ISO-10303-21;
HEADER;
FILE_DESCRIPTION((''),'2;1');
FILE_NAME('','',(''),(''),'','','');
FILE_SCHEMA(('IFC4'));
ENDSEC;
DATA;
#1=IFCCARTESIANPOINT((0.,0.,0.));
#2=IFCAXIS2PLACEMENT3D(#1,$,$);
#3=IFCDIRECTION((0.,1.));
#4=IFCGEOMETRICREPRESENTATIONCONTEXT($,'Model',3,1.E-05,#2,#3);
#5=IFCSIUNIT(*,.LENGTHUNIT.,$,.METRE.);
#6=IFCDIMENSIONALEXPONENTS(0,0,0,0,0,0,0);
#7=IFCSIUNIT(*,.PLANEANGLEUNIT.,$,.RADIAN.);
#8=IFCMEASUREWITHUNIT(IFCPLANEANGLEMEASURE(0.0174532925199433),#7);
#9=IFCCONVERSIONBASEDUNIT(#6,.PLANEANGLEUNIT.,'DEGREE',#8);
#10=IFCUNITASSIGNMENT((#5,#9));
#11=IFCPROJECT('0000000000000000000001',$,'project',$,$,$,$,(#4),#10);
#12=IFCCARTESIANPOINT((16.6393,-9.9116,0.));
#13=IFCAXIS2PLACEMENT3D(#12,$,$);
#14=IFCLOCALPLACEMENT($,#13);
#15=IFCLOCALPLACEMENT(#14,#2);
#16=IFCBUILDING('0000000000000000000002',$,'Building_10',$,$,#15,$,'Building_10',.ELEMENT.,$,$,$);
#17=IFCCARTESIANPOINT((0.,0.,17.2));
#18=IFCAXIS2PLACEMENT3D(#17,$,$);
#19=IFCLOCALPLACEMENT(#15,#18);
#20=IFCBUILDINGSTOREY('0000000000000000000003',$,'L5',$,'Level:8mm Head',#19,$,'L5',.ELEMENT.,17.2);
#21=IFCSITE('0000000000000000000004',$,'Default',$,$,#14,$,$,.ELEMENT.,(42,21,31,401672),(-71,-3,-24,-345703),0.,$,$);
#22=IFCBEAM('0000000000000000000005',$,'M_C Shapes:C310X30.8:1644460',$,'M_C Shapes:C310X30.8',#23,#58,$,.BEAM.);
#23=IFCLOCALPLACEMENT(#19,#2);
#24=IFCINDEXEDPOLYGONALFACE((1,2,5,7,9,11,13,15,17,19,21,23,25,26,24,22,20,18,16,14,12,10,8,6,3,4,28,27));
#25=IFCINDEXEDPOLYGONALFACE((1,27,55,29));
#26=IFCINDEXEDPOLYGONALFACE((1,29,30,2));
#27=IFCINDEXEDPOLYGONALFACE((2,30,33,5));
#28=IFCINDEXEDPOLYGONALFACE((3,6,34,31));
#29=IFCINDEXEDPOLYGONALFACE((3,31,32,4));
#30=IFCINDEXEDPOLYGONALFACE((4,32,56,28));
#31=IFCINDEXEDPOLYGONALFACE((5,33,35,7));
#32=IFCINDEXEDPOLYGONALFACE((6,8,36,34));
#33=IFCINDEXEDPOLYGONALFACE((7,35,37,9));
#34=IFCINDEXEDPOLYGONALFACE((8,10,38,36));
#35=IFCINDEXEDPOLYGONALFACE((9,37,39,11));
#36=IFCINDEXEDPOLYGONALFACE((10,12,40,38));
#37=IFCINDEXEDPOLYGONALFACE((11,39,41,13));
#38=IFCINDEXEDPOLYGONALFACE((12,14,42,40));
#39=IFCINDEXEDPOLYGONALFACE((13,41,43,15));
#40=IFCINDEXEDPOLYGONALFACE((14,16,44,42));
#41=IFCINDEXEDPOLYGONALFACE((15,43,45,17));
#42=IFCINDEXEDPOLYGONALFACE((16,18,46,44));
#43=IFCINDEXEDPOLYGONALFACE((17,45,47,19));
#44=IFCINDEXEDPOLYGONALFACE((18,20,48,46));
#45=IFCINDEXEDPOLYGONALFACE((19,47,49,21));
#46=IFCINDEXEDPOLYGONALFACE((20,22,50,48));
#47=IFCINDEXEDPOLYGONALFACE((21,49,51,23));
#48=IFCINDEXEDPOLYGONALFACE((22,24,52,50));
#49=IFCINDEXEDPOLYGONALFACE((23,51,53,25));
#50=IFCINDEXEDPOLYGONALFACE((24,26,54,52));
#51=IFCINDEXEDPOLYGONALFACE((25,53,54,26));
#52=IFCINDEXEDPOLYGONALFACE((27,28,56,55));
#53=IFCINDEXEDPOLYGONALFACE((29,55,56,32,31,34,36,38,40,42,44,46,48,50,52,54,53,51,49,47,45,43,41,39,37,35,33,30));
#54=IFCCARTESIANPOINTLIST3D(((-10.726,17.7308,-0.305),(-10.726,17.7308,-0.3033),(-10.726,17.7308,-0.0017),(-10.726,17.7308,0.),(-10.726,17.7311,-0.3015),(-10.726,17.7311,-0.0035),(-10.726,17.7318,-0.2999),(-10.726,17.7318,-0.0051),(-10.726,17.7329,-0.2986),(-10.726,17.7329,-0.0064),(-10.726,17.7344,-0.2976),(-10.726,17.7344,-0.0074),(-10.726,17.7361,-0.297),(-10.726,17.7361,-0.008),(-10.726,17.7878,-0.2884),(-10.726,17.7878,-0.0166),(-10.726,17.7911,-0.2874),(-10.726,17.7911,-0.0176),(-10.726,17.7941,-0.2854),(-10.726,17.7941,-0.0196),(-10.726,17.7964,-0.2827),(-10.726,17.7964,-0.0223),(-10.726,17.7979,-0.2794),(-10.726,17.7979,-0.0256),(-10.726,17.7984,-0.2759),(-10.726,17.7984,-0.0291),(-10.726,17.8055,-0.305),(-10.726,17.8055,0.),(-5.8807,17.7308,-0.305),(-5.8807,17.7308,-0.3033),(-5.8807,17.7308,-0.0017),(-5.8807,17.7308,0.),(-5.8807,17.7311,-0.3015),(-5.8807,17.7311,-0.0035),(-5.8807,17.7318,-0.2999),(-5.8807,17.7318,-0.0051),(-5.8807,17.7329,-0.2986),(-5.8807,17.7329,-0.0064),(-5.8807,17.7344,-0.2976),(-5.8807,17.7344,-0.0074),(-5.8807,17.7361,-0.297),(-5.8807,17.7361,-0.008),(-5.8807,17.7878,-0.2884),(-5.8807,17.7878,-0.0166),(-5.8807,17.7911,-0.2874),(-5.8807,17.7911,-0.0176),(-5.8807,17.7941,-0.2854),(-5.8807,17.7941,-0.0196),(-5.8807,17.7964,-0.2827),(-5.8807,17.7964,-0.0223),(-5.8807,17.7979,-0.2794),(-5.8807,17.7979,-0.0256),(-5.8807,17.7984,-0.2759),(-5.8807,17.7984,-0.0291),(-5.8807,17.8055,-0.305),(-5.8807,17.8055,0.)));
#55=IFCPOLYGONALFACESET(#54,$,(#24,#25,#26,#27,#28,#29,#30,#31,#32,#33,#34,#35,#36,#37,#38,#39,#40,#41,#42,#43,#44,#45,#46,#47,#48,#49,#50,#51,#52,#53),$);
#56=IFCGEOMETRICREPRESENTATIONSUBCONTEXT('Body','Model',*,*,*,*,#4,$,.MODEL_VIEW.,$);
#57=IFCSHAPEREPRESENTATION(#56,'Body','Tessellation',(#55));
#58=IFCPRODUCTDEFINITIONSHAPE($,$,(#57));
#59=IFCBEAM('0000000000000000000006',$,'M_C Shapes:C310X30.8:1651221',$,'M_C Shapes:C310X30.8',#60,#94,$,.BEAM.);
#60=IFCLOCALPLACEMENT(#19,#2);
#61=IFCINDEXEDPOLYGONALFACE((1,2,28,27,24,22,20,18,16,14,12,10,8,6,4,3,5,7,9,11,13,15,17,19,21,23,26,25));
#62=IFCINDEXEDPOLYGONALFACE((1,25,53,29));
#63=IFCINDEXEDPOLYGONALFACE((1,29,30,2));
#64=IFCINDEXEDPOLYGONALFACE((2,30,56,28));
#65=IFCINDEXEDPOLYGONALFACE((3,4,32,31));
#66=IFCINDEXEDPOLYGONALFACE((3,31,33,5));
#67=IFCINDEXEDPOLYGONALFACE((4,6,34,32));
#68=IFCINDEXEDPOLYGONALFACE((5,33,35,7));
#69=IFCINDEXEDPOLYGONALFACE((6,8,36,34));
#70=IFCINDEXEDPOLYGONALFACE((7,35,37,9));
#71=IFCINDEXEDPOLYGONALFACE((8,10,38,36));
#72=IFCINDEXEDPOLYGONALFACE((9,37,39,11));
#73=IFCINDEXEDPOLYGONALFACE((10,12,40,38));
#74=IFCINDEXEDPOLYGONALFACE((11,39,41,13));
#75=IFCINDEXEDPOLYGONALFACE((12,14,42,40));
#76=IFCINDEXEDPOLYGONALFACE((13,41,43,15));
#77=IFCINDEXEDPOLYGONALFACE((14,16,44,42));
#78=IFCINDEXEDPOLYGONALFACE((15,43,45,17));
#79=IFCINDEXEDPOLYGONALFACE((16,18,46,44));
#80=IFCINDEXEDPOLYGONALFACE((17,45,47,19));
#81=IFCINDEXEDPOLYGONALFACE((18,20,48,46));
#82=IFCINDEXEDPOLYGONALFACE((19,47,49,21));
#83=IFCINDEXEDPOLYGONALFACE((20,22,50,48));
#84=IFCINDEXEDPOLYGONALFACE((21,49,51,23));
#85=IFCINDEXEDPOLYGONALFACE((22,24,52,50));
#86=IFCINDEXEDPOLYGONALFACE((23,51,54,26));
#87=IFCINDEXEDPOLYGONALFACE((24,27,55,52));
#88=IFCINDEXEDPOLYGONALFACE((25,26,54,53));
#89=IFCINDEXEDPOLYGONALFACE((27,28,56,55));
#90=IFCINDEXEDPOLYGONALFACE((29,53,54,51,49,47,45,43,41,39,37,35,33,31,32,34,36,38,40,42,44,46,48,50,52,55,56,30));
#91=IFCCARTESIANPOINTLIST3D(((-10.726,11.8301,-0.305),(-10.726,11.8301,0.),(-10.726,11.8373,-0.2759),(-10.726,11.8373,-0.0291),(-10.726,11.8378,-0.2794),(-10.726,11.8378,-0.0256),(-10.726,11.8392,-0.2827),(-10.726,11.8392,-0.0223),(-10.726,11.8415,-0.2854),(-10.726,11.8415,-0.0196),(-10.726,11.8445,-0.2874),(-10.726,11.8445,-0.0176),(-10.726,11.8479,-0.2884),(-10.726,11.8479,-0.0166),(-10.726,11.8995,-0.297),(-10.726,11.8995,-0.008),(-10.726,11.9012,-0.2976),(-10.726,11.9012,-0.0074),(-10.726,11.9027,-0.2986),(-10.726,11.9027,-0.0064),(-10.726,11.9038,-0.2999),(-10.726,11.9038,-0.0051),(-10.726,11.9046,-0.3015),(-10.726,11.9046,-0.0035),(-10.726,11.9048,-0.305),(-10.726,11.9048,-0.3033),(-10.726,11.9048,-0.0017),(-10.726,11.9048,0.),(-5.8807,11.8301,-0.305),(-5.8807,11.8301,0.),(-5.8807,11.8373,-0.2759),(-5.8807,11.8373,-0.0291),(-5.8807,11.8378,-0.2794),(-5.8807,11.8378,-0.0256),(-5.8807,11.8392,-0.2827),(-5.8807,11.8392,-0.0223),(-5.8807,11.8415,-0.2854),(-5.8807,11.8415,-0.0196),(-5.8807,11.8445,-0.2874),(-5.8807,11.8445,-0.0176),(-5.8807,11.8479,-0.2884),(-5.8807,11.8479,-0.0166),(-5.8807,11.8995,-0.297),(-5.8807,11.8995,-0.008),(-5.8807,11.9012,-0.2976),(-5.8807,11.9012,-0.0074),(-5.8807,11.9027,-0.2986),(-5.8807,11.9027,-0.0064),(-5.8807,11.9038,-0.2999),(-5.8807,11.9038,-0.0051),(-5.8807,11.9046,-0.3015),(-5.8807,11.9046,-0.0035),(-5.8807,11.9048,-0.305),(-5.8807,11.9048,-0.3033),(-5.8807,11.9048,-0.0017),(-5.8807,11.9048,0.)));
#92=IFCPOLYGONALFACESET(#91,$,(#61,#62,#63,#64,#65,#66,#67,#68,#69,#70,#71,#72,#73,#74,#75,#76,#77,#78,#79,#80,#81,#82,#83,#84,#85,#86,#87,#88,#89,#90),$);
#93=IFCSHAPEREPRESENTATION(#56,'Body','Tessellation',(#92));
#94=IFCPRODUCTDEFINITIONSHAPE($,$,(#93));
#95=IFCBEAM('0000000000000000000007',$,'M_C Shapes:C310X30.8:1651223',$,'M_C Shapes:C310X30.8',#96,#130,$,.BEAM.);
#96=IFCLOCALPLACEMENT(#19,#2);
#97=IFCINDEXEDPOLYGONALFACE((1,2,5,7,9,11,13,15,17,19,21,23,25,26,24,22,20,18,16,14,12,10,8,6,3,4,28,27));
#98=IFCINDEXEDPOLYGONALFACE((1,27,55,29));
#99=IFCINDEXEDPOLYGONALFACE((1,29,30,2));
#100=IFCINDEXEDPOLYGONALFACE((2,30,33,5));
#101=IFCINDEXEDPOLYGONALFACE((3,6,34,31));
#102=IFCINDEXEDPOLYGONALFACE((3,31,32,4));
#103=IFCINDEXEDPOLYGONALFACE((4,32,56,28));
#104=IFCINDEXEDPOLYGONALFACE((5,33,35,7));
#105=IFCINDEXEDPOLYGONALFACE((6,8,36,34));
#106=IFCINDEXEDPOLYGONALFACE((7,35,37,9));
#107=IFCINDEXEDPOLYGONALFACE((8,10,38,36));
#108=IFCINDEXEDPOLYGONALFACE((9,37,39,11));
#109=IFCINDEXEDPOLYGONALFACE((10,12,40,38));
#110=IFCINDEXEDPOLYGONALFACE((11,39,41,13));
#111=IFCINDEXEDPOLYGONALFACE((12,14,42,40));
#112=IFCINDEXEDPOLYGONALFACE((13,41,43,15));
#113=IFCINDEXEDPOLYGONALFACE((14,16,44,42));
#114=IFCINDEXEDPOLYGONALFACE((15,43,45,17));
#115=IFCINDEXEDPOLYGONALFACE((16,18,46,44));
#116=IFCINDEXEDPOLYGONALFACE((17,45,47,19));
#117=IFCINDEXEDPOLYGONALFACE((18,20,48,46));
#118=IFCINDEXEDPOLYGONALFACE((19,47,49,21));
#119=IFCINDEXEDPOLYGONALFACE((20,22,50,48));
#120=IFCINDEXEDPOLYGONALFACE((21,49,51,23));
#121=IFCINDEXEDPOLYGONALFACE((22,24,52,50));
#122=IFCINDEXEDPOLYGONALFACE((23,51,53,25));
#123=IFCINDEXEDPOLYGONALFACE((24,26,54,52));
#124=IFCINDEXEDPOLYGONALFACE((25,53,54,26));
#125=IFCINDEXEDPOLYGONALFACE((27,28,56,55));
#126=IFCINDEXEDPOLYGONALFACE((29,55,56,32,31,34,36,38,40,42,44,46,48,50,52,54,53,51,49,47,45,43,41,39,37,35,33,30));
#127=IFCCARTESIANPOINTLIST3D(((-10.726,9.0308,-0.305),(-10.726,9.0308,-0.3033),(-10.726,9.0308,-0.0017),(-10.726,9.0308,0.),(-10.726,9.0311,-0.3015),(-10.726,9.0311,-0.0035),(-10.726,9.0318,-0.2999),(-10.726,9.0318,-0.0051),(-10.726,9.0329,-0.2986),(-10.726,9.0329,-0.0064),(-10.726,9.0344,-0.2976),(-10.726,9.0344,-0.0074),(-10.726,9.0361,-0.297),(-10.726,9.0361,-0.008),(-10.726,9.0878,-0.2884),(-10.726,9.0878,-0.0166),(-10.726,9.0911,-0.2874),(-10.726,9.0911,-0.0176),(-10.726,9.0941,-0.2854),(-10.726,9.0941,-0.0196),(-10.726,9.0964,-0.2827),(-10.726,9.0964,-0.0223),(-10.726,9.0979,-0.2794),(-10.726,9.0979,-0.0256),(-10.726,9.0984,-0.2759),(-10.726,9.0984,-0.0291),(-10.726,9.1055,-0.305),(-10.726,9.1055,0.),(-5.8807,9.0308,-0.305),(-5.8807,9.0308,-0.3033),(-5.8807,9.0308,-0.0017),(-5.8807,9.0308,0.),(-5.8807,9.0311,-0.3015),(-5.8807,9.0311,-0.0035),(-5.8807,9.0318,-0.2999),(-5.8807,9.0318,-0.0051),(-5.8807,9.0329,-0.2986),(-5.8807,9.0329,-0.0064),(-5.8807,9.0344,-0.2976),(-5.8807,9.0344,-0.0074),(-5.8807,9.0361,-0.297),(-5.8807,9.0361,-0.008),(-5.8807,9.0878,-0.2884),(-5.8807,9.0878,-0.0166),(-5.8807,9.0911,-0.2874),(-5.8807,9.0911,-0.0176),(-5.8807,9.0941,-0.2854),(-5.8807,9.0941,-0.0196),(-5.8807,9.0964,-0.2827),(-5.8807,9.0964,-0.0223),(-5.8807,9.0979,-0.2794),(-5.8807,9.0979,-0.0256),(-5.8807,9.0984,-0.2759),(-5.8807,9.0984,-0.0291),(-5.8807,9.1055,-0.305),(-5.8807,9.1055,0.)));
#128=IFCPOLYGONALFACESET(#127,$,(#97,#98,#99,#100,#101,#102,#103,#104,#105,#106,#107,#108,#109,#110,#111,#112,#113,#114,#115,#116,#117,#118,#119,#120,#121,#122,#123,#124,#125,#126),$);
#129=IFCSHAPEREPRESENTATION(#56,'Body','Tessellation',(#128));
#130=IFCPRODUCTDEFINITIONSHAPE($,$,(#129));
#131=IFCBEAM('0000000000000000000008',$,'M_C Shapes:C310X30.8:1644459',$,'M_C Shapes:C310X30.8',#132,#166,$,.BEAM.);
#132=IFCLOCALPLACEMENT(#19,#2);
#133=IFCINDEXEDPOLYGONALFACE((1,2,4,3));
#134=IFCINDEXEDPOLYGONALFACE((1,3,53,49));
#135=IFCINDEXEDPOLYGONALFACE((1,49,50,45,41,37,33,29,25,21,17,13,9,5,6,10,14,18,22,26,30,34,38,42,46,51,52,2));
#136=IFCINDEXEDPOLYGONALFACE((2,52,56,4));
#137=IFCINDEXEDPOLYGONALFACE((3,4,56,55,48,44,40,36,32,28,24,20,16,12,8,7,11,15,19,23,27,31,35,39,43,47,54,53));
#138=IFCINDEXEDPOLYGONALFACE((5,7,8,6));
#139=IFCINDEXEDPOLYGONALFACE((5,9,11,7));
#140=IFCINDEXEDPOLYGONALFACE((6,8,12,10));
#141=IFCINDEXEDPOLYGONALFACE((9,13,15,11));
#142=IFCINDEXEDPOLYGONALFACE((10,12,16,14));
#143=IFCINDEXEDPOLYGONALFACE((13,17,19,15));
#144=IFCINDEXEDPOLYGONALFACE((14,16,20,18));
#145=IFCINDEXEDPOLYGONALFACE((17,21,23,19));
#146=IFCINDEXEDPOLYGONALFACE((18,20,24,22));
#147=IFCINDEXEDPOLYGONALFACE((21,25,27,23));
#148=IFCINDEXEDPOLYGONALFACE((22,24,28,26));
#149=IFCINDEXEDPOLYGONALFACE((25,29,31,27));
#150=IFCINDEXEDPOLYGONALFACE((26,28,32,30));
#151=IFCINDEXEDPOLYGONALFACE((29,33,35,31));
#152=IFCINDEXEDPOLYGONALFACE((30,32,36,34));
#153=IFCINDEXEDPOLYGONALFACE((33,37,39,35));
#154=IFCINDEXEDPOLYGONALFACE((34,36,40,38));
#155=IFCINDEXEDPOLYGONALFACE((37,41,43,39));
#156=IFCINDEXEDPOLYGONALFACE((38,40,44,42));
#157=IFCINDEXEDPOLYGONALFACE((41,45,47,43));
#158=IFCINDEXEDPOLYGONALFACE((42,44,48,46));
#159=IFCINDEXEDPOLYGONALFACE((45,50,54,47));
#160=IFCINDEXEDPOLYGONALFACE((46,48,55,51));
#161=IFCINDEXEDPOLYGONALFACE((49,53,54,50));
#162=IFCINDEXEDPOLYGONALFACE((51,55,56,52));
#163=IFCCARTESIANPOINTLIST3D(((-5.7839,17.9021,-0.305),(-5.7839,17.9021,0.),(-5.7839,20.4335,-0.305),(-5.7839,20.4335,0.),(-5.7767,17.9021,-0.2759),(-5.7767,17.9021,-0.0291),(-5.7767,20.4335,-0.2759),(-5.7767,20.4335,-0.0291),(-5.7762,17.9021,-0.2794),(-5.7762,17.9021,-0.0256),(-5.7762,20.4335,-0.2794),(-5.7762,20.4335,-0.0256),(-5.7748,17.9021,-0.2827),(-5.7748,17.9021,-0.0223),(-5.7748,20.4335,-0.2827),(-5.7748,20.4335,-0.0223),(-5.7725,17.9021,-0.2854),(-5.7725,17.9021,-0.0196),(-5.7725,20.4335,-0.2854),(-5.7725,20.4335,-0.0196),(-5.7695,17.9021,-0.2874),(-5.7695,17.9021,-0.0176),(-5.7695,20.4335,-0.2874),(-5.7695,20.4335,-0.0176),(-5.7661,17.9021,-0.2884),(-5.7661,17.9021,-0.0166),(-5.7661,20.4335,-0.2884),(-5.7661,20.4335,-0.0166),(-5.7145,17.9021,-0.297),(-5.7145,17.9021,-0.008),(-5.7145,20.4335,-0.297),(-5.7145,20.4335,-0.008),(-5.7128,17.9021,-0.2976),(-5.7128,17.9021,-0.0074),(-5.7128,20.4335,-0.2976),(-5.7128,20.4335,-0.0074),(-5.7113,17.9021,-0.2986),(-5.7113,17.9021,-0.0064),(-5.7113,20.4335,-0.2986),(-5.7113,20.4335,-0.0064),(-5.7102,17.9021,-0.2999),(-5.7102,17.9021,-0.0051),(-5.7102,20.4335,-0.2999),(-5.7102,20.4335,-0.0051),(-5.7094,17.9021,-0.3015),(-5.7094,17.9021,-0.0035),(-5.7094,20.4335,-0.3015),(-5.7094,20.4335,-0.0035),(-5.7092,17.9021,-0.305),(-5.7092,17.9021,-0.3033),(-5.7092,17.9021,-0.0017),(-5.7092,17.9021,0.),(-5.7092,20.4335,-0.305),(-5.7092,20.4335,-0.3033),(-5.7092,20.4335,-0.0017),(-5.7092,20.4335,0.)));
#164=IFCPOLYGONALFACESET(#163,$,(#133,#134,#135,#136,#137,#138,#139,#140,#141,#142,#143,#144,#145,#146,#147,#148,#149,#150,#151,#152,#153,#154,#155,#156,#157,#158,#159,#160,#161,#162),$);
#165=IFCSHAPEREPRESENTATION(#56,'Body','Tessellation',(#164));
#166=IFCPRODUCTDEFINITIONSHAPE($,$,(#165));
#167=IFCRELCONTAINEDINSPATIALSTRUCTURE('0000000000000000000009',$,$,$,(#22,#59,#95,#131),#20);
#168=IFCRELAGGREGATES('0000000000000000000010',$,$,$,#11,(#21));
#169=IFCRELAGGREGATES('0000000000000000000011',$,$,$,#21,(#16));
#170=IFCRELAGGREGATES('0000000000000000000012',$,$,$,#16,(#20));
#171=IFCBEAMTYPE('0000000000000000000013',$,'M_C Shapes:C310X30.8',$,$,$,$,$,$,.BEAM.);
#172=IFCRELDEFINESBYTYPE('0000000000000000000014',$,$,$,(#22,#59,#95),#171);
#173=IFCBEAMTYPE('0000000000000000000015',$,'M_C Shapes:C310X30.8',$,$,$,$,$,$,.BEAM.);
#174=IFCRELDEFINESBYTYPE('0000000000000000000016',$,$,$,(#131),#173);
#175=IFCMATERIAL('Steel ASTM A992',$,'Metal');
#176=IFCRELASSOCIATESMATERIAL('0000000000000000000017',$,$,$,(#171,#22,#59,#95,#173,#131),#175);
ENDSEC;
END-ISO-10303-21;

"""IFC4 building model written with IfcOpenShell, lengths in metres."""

from ifc_helpers import new_model, entity, si_unit, converted_unit, direction, frame, origin, place, context, subcontext, project, spatial, line, arc, indexed_curve, outline, extrude, source, transform, mapped, material, type_object, type_shapes, element, save


model = new_model("IFC4")

# Units and contexts
model_context = context("Model", 3, precision=1e-05, world=origin(), true_north=direction((0.0, 1.0)))
body_context = subcontext(model_context, "Body", "Model", "MODEL_VIEW")
ifc_project = project(units=[si_unit("LENGTHUNIT", "METRE"), converted_unit("PLANEANGLEUNIT", "DEGREE", entity("IfcPlaneAngleMeasure", 0.0174532925199433), si_unit("PLANEANGLEUNIT", "RADIAN"), dimensions=[0, 0, 0, 0, 0, 0, 0])], contexts=[model_context])

# Site, building, storey
site_placement = place(None, frame((16.6393, -9.9116, 0.0)))
site = spatial("IfcSite", under=ifc_project, at=site_placement, Name="Default", CompositionType="ELEMENT", RefLatitude=(42, 21, 31, 401672), RefLongitude=(-71, -3, -24, -345703), RefElevation=0.0)
building_placement = place(site_placement, origin())
building = spatial("IfcBuilding", under=site, at=building_placement, Name="Building_10", LongName="Building_10", CompositionType="ELEMENT")
storey_placement = place(building_placement, frame((0.0, 0.0, 17.2)))
storey = spatial("IfcBuildingStorey", under=building, at=storey_placement, Name="L5", ObjectType="Level:8mm Head", LongName="L5", CompositionType="ELEMENT", Elevation=17.2)

# Shared definitions
ifc_material = material(Name="Steel ASTM A992", Category="Metal")

# Beams
beam_type_1 = type_object("IfcBeamType", Name="M_C Shapes:C310X30.8", PredefinedType="BEAM", material=ifc_material)
shared_shape_1 = source(origin(), body_context, "Body", "SweptSolid", [
    extrude(outline(indexed_curve([(-0.0406, -0.1525), (0.0341, -0.1525), (0.0341, -0.1508), (0.0326, -0.1467), (0.0288, -0.1445), (-0.0228, -0.1359), (-0.0305, -0.1316), (-0.0335, -0.1234), (-0.0335, 0.1234), (-0.0305, 0.1316), (-0.0228, 0.1359), (0.0288, 0.1445), (0.0326, 0.1467), (0.0341, 0.1508), (0.0341, 0.1525), (-0.0406, 0.1525)], segments=[line(1, 2, 3), arc(3, 4, 5), line(5, 6), arc(6, 7, 8), line(8, 9), arc(9, 10, 11), line(11, 12), arc(12, 13, 14), line(14, 15, 16, 1)], self_intersect=False)), frame((-2.4226, -0.0229, 0.0), z_axis=(1.0, 0.0, 0.0), x_axis=(0.0, -1.0, 0.0)), (0.0, 0.0, 1.0), 4.8453),
])
type_shapes(beam_type_1, [shared_shape_1])
beam_1_placement = place(storey_placement, frame((-8.3033, 17.7878, -0.1525)))
element("IfcBeam", 1, at=beam_1_placement, inside=storey, type_object=beam_type_1, material=ifc_material, Name="M_C Shapes:C310X30.8:1644460", ObjectType="M_C Shapes:C310X30.8", PredefinedType="BEAM", context=body_context, shape_type="MappedRepresentation", body=[
    mapped(shared_shape_1, transform((0.0, 0.0, 0.0), scale=1.0)),
])
beam_2_placement = place(storey_placement, frame((-8.3033, 11.8478, -0.1525), z_axis=(0.0, 0.0, 1.0), x_axis=(-1.0, 0.0, 0.0)))
element("IfcBeam", 2, at=beam_2_placement, inside=storey, type_object=beam_type_1, material=ifc_material, Name="M_C Shapes:C310X30.8:1651221", ObjectType="M_C Shapes:C310X30.8", PredefinedType="BEAM", context=body_context, shape_type="MappedRepresentation", body=[
    mapped(shared_shape_1, transform((0.0, 0.0, 0.0), scale=1.0)),
])
beam_3_placement = place(storey_placement, frame((-8.3033, 9.0878, -0.1525)))
element("IfcBeam", 3, at=beam_3_placement, inside=storey, type_object=beam_type_1, material=ifc_material, Name="M_C Shapes:C310X30.8:1651223", ObjectType="M_C Shapes:C310X30.8", PredefinedType="BEAM", context=body_context, shape_type="MappedRepresentation", body=[
    mapped(shared_shape_1, transform((0.0, 0.0, 0.0), scale=1.0)),
])
beam_type_2 = type_object("IfcBeamType", Name="M_C Shapes:C310X30.8", PredefinedType="BEAM", material=ifc_material)
shared_shape_2 = source(origin(), body_context, "Body", "SweptSolid", [
    extrude(outline(indexed_curve([(-0.0406, -0.1525), (0.0341, -0.1525), (0.0341, -0.1508), (0.0326, -0.1467), (0.0288, -0.1445), (-0.0228, -0.1359), (-0.0305, -0.1316), (-0.0335, -0.1234), (-0.0335, 0.1234), (-0.0305, 0.1316), (-0.0228, 0.1359), (0.0288, 0.1445), (0.0326, 0.1467), (0.0341, 0.1508), (0.0341, 0.1525), (-0.0406, 0.1525)], segments=[line(1, 2, 3), arc(3, 4, 5), line(5, 6), arc(6, 7, 8), line(8, 9), arc(9, 10, 11), line(11, 12), arc(12, 13, 14), line(14, 15, 16, 1)], self_intersect=False)), frame((-1.2657, -0.0229, 0.0), z_axis=(1.0, 0.0, 0.0), x_axis=(0.0, -1.0, 0.0)), (0.0, 0.0, 1.0), 2.5314),
])
type_shapes(beam_type_2, [shared_shape_2])
for number, where, z_axis, x_axis, name in (
    (4, (-5.7662, 19.1678, -0.1525), (0.0, 0.0, 1.0), (0.0, 1.0, 0.0), "M_C Shapes:C310X30.8:1644459"),
):
    element("IfcBeam", number, at=place(storey_placement, frame(where, z_axis=z_axis, x_axis=x_axis)), inside=storey, type_object=beam_type_2, material=ifc_material, Name=name, ObjectType="M_C Shapes:C310X30.8", PredefinedType="BEAM", context=body_context, shape_type="MappedRepresentation", body=[
        mapped(shared_shape_2, transform((0.0, 0.0, 0.0), scale=1.0)),
    ])

save(model, "model.ifc")
